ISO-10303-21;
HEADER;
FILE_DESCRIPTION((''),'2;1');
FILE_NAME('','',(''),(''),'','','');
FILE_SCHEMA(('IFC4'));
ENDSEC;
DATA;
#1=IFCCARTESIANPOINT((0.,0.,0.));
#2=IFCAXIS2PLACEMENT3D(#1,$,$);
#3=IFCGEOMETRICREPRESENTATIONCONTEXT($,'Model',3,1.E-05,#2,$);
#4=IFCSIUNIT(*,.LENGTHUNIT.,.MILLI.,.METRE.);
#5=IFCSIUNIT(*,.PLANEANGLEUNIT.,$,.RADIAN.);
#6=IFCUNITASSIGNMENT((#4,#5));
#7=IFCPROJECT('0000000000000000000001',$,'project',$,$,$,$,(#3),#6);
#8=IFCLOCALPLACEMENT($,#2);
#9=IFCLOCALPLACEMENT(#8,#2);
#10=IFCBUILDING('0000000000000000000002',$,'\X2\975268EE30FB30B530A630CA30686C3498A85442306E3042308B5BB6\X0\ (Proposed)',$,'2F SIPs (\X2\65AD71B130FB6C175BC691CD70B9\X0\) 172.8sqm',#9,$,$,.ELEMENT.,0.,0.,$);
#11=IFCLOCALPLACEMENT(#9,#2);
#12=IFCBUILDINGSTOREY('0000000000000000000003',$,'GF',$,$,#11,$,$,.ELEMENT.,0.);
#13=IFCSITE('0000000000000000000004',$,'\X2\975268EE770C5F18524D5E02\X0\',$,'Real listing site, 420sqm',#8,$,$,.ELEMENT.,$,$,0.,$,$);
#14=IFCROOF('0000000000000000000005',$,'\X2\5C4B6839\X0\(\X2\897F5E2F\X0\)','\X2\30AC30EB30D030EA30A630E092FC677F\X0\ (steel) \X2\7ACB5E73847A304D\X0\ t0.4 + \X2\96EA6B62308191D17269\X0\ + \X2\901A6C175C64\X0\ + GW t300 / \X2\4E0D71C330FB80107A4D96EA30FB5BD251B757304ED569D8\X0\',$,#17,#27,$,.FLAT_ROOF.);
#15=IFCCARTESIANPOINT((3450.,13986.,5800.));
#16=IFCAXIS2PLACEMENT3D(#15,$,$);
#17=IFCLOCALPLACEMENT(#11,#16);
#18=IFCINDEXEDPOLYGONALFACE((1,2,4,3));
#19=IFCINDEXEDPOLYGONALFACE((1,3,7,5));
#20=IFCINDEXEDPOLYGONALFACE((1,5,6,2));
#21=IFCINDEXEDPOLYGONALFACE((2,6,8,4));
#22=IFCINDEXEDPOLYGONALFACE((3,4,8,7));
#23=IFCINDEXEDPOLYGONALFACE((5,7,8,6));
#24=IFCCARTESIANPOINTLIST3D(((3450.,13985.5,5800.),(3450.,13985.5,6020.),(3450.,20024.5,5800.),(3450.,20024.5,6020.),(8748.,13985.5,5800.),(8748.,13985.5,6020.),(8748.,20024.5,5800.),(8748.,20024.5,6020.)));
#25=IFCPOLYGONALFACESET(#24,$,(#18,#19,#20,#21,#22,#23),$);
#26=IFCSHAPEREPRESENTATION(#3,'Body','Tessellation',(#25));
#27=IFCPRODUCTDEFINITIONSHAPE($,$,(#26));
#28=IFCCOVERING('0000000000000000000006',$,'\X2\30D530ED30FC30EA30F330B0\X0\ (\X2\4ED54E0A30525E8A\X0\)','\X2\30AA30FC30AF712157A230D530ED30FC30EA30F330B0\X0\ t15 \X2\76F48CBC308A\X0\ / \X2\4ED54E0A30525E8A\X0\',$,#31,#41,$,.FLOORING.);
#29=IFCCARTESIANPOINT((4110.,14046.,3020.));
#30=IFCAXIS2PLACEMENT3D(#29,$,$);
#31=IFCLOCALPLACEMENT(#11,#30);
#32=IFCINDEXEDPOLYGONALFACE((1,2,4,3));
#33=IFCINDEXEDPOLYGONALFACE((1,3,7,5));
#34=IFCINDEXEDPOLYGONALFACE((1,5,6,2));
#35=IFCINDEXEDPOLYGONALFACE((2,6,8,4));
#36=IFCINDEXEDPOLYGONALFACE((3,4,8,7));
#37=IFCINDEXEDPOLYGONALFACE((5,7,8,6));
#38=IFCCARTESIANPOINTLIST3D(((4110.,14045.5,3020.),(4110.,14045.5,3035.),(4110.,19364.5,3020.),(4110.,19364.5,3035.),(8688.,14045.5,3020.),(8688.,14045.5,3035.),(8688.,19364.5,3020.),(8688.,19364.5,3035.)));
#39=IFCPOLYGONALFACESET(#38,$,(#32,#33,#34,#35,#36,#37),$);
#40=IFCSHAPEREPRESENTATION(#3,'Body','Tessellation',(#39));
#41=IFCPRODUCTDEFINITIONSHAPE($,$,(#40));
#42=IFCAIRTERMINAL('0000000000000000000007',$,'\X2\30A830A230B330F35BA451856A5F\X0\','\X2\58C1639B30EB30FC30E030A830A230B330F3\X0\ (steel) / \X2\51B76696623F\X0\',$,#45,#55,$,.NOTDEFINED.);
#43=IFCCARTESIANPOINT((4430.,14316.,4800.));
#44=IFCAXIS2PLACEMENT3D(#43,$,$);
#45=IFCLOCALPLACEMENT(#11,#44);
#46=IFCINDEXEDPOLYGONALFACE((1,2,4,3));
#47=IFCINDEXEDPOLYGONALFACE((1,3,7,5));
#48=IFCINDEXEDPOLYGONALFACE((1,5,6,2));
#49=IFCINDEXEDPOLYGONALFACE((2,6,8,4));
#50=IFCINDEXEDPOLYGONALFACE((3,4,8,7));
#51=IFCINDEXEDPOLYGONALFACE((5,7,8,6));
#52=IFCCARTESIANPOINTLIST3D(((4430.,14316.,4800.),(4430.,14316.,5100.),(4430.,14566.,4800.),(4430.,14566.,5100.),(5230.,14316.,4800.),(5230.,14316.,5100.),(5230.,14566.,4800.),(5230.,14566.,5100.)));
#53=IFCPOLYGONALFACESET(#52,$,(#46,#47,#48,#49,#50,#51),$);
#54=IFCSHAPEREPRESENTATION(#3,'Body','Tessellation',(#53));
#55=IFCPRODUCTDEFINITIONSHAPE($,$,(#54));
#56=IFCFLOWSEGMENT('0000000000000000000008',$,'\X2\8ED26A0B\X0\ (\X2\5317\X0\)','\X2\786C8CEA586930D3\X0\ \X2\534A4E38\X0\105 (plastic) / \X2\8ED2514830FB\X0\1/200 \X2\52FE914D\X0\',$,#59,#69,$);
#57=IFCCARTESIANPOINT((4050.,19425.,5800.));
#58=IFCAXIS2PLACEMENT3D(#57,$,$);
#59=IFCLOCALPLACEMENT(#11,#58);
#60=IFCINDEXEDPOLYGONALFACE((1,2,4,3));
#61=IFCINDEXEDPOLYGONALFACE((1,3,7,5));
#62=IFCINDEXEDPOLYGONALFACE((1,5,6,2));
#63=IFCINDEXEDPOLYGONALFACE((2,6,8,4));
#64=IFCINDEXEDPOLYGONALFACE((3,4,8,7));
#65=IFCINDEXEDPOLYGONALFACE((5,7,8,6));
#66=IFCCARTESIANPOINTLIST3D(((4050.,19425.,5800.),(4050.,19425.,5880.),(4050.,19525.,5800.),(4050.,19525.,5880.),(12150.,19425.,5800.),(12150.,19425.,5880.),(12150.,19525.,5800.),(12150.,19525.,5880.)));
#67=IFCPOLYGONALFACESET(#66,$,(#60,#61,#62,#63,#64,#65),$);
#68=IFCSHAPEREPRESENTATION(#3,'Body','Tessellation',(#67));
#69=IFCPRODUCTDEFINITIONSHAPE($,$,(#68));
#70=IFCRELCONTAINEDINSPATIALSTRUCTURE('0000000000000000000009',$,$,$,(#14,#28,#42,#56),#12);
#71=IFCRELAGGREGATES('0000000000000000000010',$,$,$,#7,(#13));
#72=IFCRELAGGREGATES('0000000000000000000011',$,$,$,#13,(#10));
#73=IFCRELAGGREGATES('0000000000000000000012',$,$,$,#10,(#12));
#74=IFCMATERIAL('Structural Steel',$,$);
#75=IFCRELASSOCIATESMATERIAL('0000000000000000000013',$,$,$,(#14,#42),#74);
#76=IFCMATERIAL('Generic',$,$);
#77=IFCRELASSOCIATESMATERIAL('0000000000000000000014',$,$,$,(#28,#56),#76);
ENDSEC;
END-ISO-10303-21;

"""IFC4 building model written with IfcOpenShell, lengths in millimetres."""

from ifc_helpers import new_model, si_unit, frame, frame_2d, origin, place, context, project, spatial, rectangle, extrude, material, element, save


model = new_model("IFC4")

# Units and contexts
model_context = context("Model", 3, precision=1e-05, world=origin())
ifc_project = project(units=[si_unit("LENGTHUNIT", "METRE", prefix="MILLI"), si_unit("PLANEANGLEUNIT", "RADIAN")], contexts=[model_context])

# Site, building, storey
site_placement = place(None, origin())
site = spatial("IfcSite", under=ifc_project, at=site_placement, Name="青森県弘前市", ObjectType="Real listing site, 420sqm", CompositionType="ELEMENT", RefElevation=0.0)
building_placement = place(site_placement, origin())
building = spatial("IfcBuilding", under=site, at=building_placement, Name="青森・サウナと水風呂のある家 (Proposed)", ObjectType="2F SIPs (断熱・気密重点) 172.8sqm", CompositionType="ELEMENT", ElevationOfRefHeight=0.0, ElevationOfTerrain=0.0)
storey_placement = place(building_placement, origin())
storey = spatial("IfcBuildingStorey", under=building, at=storey_placement, Name="GF", CompositionType="ELEMENT", Elevation=0.0)

# Roof
ifc_material_1 = material(Name="Structural Steel")
for number, where, name in (
    (1, (3450.0, 13986.0, 5800.0), "屋根(西帯)"),
):
    element("IfcRoof", number, at=place(storey_placement, frame(where)), inside=storey, material=ifc_material_1, Name=name, Description="ガルバリウム鋼板 (steel) 立平葺き t0.4 + 雪止め金物 + 通気層 + GW t300 / 不燃・耐積雪・寒冷地仕様", PredefinedType="FLAT_ROOF", context=model_context, shape_type="SweptSolid", body=[
        extrude(rectangle(XDim=5298.0, YDim=6039.0, at=frame_2d((2649.0, 3019.0))), frame((3450.0, 13986.0, 5800.0)), (0.0, 0.0, 1.0), 220.0),
    ])

# Covering
ifc_material_2 = material(Name="Generic")
covering_placement = place(storey_placement, frame((4110.0, 14046.0, 3020.0)))
element("IfcCovering", 2, at=covering_placement, inside=storey, material=ifc_material_2, Name="フローリング (仕上げ床)", Description="オーク無垢フローリング t15 直貼り / 仕上げ床", PredefinedType="FLOORING", context=model_context, shape_type="SweptSolid", body=[
    extrude(rectangle(XDim=4578.0, YDim=5319.0, at=frame_2d((2289.0, 2659.0))), frame((4110.0, 14046.0, 3020.0)), (0.0, 0.0, 1.0), 15.0),
])

# Air terminal
air_terminal_placement = place(storey_placement, frame((4430.0, 14316.0, 4800.0)))
element("IfcAirTerminal", 3, at=air_terminal_placement, inside=storey, material=ifc_material_1, Name="エアコン室内機", Description="壁掛ルームエアコン (steel) / 冷暖房", PredefinedType="NOTDEFINED", context=model_context, shape_type="SweptSolid", body=[
    extrude(rectangle(XDim=800.0, YDim=250.0, at=frame_2d((400.0, 125.0))), frame((4430.0, 14316.0, 4800.0)), (0.0, 0.0, 1.0), 300.0),
])

# Flow segment
flow_segment_placement = place(storey_placement, frame((4050.0, 19425.0, 5800.0)))
element("IfcFlowSegment", 4, at=flow_segment_placement, inside=storey, material=ifc_material_2, Name="軒樋 (北)", Description="硬質塩ビ 半丸105 (plastic) / 軒先・1/200 勾配", context=model_context, shape_type="SweptSolid", body=[
    extrude(rectangle(XDim=8100.0, YDim=100.0, at=frame_2d((4050.0, 50.0))), frame((4050.0, 19425.0, 5800.0)), (0.0, 0.0, 1.0), 80.0),
])

save(model, "model.ifc")
